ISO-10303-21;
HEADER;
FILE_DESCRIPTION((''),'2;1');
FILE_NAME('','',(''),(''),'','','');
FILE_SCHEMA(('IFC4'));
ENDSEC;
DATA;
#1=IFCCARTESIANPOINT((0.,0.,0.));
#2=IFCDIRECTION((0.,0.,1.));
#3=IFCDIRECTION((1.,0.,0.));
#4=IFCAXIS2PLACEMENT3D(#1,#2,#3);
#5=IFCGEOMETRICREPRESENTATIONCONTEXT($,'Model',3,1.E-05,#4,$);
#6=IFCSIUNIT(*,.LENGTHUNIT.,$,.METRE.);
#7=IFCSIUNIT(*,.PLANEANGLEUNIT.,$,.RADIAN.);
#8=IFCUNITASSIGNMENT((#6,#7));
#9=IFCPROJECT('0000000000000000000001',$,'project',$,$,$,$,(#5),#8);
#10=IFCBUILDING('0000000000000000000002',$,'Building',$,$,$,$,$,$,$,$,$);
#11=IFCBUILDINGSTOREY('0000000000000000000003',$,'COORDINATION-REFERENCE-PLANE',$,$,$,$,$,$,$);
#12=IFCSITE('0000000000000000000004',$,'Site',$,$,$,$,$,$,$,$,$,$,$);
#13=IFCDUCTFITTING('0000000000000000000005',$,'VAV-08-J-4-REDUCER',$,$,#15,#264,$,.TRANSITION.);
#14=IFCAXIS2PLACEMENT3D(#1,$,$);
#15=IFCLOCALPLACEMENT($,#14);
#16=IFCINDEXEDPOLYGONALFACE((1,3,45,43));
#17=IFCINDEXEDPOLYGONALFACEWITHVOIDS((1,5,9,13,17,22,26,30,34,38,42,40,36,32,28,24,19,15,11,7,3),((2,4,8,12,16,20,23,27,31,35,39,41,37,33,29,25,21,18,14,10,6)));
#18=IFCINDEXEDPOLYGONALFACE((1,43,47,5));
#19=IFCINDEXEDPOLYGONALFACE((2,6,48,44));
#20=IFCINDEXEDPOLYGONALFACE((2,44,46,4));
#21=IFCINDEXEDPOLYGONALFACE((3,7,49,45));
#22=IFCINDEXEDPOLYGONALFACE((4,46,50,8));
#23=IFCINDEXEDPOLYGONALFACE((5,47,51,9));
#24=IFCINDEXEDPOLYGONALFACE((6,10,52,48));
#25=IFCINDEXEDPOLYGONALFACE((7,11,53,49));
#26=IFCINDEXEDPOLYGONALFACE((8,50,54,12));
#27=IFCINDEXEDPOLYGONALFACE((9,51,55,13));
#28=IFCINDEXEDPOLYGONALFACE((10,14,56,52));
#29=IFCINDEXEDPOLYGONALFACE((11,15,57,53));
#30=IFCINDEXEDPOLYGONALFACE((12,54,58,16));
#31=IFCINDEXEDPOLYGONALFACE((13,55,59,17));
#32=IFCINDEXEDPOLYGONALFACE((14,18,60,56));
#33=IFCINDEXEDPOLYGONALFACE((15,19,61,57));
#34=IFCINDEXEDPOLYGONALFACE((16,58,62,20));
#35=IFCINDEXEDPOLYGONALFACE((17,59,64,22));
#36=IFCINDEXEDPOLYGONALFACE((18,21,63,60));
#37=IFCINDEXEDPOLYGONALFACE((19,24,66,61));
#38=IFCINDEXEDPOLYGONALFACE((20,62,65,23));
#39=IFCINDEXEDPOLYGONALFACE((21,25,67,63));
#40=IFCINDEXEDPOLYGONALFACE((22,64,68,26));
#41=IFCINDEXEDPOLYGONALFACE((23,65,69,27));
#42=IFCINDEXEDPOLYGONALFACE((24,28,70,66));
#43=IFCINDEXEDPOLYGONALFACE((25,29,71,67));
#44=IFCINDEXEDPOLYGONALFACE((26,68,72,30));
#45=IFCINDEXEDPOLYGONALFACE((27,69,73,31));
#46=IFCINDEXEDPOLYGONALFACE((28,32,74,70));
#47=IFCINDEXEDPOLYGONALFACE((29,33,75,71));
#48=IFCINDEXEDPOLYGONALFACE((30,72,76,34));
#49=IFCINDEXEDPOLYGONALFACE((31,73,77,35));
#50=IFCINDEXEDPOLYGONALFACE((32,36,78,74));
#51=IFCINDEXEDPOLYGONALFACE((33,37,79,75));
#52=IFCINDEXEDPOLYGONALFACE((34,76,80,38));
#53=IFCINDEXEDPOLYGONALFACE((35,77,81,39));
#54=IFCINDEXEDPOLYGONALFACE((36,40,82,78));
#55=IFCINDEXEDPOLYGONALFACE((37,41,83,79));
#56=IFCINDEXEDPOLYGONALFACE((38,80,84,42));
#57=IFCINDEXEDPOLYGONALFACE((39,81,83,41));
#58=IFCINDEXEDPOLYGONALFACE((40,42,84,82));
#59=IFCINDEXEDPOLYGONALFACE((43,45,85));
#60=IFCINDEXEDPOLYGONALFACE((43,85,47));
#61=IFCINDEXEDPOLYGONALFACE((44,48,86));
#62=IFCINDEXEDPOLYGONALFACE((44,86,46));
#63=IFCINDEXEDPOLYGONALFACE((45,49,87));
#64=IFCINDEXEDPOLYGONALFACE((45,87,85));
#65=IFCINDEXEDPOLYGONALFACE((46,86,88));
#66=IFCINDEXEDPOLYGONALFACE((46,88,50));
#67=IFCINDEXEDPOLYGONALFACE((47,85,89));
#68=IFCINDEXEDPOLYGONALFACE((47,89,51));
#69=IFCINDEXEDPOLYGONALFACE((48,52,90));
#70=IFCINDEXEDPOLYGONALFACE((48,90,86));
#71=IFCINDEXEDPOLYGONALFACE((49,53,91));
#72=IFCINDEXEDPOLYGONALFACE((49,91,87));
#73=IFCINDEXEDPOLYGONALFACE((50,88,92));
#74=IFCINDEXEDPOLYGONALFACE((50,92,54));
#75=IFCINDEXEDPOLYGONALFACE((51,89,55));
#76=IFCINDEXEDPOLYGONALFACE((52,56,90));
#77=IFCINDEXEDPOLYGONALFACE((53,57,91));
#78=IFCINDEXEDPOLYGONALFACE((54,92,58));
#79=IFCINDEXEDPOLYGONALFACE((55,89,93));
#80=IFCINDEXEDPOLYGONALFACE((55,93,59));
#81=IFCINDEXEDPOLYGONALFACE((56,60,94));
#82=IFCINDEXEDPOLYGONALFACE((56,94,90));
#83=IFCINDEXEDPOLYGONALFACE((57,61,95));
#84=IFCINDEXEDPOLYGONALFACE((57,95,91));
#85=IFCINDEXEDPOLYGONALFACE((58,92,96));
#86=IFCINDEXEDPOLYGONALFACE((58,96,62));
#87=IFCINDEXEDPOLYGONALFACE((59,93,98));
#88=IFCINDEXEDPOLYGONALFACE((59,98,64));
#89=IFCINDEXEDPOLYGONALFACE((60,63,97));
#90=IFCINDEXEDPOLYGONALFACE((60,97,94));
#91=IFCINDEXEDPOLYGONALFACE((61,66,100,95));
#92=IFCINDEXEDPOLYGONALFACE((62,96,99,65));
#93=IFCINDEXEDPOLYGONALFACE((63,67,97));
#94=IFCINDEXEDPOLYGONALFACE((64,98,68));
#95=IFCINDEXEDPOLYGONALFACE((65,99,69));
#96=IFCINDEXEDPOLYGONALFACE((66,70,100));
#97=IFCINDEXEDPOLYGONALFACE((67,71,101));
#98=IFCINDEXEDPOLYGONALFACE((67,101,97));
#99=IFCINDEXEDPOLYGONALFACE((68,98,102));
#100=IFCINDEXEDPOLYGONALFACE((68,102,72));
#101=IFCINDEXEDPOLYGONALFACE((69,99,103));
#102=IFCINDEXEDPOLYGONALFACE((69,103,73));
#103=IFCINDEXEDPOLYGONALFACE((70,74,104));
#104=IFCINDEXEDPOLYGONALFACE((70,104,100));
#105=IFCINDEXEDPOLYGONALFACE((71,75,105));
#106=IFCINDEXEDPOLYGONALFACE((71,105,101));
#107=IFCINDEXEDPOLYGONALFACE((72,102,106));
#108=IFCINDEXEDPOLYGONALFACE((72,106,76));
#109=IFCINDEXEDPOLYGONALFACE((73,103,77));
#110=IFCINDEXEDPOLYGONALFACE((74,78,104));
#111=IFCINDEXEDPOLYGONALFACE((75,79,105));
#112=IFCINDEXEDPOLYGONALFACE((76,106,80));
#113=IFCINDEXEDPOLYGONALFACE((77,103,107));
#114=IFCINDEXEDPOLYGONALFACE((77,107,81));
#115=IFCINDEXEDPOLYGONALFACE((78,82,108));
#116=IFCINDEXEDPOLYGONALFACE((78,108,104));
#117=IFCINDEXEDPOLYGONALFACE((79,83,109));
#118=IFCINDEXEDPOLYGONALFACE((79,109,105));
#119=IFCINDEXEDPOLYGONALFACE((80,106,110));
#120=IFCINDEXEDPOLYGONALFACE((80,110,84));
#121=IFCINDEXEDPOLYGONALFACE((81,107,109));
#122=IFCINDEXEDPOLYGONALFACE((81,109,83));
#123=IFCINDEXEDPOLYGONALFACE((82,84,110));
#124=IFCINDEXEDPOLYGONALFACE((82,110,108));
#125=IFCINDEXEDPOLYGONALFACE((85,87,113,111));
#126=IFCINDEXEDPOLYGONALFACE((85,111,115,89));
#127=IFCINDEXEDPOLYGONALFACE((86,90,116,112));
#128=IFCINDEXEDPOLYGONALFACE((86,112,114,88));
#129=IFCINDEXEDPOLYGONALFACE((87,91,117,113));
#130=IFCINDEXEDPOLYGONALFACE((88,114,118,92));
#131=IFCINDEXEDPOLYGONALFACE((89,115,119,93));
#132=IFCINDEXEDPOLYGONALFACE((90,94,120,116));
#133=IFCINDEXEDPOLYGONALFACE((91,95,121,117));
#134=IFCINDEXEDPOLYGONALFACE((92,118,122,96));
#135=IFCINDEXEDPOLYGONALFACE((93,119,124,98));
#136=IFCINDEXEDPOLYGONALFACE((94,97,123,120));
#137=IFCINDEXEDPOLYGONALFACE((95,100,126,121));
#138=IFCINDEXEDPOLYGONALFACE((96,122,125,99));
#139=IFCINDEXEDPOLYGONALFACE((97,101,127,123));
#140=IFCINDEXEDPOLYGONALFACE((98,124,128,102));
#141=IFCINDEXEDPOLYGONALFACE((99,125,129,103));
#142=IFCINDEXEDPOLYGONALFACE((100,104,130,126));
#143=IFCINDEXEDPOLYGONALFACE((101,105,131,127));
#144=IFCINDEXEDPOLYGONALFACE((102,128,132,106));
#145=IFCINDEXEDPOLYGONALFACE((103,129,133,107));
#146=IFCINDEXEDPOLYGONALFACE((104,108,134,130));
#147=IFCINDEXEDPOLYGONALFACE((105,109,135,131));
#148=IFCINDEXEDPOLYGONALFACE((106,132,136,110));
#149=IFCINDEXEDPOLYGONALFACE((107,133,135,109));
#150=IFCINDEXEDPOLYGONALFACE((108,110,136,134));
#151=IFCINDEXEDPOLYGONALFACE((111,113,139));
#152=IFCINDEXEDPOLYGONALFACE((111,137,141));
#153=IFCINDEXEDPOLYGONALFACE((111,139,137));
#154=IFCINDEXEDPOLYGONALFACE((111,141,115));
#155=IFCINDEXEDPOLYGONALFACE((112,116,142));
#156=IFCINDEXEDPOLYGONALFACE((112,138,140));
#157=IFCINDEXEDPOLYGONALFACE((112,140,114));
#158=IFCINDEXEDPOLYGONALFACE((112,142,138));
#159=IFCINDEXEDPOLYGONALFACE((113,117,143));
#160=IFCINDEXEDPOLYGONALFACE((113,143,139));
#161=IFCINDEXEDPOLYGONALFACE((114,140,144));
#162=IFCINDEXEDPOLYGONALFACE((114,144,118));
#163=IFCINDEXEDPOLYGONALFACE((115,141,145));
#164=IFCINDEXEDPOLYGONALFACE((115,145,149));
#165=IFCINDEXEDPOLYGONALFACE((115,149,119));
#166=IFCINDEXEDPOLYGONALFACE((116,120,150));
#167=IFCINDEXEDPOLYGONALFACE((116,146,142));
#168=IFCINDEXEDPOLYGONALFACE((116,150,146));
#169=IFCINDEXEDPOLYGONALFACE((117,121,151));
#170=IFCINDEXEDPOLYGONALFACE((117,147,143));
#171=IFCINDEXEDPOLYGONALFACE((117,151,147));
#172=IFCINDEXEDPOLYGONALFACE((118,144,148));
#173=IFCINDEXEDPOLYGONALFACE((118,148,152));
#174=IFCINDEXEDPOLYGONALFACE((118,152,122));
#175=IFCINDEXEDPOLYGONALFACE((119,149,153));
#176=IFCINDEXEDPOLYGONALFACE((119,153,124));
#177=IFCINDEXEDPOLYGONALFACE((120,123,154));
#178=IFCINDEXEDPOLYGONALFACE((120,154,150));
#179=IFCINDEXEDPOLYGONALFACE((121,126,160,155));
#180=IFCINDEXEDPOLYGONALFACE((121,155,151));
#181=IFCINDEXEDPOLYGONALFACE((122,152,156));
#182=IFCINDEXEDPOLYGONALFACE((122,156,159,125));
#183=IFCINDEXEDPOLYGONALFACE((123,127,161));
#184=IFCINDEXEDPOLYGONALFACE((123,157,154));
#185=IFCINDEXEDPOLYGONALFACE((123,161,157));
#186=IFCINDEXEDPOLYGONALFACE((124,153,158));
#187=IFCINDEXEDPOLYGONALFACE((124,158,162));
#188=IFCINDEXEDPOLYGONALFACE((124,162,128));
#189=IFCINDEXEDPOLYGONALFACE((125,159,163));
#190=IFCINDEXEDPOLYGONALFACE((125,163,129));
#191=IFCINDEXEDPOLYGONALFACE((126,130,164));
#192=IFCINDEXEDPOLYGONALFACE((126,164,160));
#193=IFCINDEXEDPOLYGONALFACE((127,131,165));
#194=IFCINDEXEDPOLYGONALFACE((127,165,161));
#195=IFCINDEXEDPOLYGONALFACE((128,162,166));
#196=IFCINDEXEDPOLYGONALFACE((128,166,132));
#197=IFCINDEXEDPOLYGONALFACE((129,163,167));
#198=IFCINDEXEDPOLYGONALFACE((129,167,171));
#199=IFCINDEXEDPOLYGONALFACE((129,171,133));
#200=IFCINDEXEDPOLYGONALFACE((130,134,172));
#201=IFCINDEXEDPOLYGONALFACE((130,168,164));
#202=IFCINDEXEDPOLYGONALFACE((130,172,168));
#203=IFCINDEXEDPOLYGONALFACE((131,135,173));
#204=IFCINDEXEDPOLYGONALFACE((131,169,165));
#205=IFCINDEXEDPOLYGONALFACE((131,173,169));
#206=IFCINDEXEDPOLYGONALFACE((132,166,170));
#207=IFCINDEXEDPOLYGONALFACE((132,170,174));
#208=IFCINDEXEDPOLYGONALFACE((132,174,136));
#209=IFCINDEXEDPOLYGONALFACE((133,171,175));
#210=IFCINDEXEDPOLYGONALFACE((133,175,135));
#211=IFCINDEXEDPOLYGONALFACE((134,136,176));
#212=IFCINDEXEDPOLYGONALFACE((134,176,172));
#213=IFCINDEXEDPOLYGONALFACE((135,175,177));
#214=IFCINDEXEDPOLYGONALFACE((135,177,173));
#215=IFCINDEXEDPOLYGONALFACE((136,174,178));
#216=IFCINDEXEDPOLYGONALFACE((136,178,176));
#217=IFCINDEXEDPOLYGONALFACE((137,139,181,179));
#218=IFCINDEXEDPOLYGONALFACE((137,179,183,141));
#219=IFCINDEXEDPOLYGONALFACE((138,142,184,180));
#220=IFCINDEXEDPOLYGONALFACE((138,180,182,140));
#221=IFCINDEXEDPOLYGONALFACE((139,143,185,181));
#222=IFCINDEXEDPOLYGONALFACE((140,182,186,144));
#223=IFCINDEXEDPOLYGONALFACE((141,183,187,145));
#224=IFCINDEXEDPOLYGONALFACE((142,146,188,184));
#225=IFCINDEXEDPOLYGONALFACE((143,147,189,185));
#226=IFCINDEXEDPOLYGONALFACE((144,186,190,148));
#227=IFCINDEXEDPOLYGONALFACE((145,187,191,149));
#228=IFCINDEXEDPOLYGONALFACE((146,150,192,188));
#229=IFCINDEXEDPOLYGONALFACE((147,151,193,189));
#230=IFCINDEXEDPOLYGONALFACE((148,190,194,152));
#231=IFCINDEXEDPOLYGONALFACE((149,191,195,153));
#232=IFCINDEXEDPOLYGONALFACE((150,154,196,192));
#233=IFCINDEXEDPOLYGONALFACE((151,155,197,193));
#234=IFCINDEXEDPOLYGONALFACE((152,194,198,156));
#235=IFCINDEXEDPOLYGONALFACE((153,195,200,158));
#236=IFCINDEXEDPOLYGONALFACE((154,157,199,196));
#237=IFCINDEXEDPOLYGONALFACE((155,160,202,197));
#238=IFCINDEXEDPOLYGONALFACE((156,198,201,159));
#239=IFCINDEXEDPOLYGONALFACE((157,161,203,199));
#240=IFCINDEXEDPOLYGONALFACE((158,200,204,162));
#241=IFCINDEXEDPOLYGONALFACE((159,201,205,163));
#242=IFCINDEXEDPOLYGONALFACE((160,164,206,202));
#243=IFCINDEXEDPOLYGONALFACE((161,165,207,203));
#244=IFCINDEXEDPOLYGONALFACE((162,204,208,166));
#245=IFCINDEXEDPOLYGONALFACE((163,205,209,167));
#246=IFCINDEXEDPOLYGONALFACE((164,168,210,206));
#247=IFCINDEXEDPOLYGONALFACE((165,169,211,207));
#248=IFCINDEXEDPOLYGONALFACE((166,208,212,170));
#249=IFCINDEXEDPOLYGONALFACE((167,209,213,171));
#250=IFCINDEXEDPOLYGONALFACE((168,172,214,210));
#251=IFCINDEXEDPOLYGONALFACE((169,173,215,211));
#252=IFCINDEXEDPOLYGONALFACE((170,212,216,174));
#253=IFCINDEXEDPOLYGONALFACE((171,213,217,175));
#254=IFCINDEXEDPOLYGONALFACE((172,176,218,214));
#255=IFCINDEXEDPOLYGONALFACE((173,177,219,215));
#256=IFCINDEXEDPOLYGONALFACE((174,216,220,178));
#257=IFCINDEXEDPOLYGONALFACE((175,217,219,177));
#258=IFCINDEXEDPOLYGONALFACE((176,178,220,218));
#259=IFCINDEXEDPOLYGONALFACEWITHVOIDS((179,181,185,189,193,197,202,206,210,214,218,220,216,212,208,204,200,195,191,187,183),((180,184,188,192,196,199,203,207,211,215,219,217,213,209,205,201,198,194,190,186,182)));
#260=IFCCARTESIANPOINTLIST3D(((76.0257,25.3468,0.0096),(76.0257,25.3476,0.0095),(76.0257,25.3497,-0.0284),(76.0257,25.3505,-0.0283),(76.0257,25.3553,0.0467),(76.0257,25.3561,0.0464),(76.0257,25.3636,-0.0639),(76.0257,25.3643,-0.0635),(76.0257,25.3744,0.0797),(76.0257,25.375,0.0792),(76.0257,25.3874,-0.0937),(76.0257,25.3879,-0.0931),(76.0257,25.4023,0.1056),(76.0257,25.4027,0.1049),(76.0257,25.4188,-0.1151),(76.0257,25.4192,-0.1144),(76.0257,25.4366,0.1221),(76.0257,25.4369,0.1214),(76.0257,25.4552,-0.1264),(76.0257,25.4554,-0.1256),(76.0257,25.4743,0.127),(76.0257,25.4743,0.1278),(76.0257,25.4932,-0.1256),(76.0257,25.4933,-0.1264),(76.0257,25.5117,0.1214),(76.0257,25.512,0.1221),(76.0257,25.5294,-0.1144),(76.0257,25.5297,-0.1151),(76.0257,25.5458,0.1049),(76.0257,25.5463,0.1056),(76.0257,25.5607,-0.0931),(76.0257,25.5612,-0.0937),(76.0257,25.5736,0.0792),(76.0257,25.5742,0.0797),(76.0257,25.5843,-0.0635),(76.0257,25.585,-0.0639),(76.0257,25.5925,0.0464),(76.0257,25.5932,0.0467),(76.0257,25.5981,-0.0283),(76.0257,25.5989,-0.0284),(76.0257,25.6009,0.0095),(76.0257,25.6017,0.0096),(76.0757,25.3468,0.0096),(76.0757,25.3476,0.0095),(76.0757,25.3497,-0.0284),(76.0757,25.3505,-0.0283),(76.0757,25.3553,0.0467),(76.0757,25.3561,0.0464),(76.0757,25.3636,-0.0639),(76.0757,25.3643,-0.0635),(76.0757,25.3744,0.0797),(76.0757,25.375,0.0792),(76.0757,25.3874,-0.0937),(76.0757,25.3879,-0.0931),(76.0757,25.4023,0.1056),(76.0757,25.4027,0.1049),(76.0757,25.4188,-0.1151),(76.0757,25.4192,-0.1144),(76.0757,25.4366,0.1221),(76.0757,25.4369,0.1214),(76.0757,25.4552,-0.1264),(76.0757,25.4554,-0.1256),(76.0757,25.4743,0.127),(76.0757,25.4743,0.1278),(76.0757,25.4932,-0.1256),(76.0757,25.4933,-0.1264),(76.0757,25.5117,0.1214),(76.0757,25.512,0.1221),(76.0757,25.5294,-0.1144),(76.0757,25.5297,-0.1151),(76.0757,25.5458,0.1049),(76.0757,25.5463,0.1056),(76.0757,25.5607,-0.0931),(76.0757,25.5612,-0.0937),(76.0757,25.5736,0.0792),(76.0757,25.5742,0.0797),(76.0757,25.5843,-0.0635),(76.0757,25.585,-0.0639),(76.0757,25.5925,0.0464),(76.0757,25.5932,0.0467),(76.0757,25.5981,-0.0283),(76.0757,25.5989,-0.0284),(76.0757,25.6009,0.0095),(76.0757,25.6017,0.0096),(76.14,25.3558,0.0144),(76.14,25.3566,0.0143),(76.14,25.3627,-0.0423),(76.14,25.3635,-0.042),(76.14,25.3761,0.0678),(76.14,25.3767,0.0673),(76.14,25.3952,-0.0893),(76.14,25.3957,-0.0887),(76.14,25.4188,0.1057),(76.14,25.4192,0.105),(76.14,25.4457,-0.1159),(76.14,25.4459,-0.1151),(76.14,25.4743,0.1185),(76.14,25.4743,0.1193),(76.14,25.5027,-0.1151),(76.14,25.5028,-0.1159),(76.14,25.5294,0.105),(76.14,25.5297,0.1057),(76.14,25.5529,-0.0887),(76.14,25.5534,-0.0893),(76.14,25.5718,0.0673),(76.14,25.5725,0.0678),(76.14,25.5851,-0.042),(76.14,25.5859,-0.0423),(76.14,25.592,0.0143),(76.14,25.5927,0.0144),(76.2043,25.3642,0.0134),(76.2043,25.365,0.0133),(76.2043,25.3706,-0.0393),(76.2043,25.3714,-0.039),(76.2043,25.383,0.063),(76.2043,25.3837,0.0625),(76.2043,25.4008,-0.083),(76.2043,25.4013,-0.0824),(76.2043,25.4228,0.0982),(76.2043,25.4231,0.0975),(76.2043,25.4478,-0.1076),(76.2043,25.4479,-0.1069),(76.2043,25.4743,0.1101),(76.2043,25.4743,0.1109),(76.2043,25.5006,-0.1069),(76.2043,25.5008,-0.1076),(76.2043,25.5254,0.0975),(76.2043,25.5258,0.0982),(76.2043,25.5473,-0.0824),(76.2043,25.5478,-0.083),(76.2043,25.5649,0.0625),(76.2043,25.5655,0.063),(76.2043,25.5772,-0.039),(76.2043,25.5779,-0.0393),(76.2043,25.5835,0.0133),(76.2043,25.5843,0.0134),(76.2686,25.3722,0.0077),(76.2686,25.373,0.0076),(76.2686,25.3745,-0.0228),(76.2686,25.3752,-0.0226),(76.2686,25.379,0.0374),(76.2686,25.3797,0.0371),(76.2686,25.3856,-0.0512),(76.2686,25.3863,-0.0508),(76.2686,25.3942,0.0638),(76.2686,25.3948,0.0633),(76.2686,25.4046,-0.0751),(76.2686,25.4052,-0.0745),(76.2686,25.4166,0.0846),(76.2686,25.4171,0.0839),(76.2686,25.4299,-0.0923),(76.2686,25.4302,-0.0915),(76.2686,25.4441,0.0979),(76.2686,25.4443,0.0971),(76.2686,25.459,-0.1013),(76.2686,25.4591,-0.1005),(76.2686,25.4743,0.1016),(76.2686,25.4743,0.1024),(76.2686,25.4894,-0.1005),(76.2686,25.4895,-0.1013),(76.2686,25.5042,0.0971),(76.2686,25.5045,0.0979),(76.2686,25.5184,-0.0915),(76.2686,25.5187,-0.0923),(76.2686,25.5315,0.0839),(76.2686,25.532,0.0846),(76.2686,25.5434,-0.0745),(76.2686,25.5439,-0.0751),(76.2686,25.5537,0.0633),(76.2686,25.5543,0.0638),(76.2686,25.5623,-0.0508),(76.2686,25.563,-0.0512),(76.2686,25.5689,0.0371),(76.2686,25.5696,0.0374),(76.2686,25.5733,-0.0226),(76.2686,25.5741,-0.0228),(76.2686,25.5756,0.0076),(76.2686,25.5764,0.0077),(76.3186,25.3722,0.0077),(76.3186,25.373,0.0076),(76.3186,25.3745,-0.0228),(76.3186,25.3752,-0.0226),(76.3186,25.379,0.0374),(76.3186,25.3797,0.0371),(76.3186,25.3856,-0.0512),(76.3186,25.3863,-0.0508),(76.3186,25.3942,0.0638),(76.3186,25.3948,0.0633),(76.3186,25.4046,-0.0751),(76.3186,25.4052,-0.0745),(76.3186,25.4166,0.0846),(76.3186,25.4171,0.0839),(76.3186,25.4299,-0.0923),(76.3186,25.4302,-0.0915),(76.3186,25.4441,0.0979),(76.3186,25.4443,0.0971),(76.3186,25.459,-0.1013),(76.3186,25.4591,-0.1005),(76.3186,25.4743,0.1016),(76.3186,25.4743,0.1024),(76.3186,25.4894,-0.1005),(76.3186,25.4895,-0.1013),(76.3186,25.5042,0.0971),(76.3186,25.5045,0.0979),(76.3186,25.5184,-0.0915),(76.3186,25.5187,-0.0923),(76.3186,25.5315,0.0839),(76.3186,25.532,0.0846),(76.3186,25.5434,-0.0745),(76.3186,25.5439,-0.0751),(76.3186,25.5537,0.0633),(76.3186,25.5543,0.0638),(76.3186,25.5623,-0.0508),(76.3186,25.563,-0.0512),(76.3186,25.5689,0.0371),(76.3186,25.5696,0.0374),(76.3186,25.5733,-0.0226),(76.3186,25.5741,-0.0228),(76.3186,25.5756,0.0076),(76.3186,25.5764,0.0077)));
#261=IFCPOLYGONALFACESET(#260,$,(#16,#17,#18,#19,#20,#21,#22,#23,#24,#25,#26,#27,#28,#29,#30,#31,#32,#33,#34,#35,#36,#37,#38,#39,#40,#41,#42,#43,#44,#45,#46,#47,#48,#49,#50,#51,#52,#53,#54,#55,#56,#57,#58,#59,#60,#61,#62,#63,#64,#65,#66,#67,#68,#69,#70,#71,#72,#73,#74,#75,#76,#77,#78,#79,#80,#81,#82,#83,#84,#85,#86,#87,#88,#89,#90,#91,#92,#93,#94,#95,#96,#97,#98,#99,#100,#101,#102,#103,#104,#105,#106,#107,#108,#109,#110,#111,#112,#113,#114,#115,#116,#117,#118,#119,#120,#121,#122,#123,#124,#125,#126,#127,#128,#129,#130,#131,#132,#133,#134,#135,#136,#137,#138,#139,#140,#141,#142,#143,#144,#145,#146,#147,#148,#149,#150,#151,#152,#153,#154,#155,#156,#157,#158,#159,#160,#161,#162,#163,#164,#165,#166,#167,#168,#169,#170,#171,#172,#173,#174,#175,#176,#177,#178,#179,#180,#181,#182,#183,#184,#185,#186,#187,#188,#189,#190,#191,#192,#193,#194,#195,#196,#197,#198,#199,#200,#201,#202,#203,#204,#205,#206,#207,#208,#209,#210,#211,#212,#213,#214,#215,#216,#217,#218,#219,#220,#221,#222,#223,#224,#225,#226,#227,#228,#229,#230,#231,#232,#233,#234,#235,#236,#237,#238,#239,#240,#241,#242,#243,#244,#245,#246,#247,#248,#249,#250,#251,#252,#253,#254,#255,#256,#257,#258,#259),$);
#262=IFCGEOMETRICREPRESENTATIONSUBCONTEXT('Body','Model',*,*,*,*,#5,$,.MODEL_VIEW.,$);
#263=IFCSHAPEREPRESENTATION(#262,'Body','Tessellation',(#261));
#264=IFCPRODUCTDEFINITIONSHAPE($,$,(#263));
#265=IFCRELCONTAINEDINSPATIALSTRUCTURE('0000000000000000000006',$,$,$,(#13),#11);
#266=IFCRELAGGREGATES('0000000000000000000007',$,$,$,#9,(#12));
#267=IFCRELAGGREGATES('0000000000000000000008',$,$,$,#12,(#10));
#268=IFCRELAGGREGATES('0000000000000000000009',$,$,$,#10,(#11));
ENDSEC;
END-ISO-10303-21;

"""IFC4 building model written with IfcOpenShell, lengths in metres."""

from ifc_helpers import new_model, entity, si_unit, frame, origin_with_axes, place, context, subcontext, project, spatial, element, save


model = new_model("IFC4")

# Units and contexts
model_context = context("Model", 3, precision=1e-05, world=origin_with_axes())
body_context_1 = subcontext(model_context, "Body", "Model", "MODEL_VIEW")
ifc_project = project(units=[si_unit("LENGTHUNIT", "METRE"), si_unit("PLANEANGLEUNIT", "RADIAN")], contexts=[model_context])

# Site, building, storey
site = spatial("IfcSite", under=ifc_project, Name="Site")
building = spatial("IfcBuilding", under=site, Name="Building")
storey = spatial("IfcBuildingStorey", under=building, Name="COORDINATION-REFERENCE-PLANE")

# Duct fitting
for number, where, z_axis, x_axis, name in (
    (1, (76.0257, 25.4743, 0.0), (0.0, 1.0, 0.0), (0.0, 0.0, 1.0), "VAV-08-J-4-REDUCER"),
):
    element("IfcDuctFitting", number, at=place(None, frame(where, z_axis=z_axis, x_axis=x_axis)), inside=storey, Name=name, PredefinedType="TRANSITION", context=body_context_1, shape_type="SweptSolid", body=[
        entity("IfcRevolvedAreaSolid", entity("IfcArbitraryClosedProfileDef", "AREA", None, entity("IfcPolyline", [entity("IfcCartesianPoint", [0.1278, 0.0]), entity("IfcCartesianPoint", [0.1278, 0.05]), entity("IfcCartesianPoint", [0.1024, 0.2429]), entity("IfcCartesianPoint", [0.1024, 0.2929]), entity("IfcCartesianPoint", [0.1016, 0.2929]), entity("IfcCartesianPoint", [0.1016, 0.2429]), entity("IfcCartesianPoint", [0.127, 0.05]), entity("IfcCartesianPoint", [0.127, 0.0]), entity("IfcCartesianPoint", [0.1278, 0.0])])), entity("IfcAxis2Placement3D", entity("IfcCartesianPoint", [0.0, 0.0, 0.0])), entity("IfcAxis1Placement", entity("IfcCartesianPoint", [0.0, 0.0, 0.0]), entity("IfcDirection", [0.0, 1.0, 0.0])), 6.283185),
    ])

save(model, "model.ifc")
